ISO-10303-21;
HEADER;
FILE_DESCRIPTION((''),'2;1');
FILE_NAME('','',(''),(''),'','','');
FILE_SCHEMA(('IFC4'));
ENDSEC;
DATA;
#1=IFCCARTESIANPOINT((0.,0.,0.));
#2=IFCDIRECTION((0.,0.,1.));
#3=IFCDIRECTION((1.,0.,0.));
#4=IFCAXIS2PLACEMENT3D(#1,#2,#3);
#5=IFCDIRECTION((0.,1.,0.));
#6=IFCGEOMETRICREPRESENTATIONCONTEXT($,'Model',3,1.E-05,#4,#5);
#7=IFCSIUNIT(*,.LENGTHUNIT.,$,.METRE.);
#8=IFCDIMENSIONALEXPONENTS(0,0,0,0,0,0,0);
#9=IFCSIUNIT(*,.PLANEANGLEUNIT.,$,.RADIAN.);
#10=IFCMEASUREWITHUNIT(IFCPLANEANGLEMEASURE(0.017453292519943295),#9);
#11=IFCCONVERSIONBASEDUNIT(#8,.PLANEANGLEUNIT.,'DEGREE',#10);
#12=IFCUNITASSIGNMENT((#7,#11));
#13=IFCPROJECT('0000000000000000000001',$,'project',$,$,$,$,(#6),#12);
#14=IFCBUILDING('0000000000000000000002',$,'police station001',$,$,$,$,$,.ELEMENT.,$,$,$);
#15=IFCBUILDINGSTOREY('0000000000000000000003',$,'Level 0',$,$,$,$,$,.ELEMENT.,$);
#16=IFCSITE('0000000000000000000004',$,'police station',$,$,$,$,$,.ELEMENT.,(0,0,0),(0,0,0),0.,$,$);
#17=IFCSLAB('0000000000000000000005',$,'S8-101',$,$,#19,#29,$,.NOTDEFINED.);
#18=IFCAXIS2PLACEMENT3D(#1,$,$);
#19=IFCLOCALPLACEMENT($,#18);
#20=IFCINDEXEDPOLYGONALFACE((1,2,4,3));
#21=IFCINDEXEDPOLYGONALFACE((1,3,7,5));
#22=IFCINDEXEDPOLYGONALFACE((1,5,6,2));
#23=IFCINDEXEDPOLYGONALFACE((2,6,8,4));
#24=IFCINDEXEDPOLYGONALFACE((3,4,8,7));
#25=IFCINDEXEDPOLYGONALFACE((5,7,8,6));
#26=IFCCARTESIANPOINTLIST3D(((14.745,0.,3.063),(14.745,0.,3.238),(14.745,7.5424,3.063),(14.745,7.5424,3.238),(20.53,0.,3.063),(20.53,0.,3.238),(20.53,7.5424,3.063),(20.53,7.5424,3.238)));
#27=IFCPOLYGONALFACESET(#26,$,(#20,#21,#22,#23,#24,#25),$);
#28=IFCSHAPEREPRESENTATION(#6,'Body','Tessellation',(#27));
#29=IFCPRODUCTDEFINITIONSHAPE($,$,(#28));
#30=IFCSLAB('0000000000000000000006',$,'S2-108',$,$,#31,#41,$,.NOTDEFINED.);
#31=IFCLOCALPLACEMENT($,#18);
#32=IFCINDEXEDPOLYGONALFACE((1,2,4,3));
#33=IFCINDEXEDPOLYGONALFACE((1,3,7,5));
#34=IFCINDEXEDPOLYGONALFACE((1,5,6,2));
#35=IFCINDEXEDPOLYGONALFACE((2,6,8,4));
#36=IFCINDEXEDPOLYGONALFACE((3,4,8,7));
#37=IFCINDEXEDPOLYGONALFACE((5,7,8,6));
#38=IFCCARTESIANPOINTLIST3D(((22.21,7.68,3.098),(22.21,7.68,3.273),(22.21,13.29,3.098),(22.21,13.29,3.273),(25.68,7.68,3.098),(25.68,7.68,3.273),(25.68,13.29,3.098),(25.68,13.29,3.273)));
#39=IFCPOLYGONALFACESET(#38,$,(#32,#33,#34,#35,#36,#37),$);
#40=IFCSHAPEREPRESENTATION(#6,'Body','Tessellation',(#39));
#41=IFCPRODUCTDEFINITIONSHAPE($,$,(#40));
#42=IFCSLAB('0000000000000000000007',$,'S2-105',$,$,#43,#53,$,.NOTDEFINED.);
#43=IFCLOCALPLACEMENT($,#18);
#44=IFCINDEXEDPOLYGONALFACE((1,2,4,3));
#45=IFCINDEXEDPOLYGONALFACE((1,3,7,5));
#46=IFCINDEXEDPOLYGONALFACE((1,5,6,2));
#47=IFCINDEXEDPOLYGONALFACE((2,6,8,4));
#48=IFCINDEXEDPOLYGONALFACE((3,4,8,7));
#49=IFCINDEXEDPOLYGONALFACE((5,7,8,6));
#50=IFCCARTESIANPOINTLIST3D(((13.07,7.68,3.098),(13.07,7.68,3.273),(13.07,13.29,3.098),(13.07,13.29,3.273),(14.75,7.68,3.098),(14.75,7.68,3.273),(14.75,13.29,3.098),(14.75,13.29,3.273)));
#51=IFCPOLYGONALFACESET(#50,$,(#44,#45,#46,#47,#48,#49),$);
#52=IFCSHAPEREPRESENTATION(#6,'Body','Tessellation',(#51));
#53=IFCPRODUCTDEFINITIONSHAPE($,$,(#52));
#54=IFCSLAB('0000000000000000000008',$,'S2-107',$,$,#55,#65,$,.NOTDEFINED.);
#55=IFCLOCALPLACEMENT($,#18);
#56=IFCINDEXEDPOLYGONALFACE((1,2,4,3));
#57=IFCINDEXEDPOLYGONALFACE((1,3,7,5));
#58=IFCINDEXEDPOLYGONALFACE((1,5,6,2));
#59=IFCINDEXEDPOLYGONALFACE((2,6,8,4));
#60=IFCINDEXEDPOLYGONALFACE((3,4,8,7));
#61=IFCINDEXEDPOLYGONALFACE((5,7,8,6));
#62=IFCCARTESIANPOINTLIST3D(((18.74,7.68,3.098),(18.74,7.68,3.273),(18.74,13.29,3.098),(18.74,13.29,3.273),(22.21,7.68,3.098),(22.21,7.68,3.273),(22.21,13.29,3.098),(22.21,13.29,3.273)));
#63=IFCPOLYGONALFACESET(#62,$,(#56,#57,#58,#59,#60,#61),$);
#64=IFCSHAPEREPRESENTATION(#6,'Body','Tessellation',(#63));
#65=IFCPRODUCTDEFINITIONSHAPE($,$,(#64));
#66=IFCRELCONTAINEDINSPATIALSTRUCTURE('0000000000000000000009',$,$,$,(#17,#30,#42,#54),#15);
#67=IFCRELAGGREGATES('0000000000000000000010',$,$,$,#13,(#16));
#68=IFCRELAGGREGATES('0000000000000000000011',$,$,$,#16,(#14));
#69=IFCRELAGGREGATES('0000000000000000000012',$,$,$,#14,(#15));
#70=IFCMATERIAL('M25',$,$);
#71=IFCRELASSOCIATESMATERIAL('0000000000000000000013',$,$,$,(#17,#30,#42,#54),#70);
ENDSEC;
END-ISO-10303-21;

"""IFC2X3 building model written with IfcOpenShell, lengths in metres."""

from ifc_helpers import new_model, entity, si_unit, converted_unit, direction, frame, frame_2d, origin_with_axes, place, context, project, spatial, rectangle, extrude, material, element, save


model = new_model("IFC2X3")

# Units and contexts
model_context = context("Model", 3, precision=1e-05, world=origin_with_axes(), true_north=direction((0.0, 1.0, 0.0)))
ifc_project = project(units=[si_unit("LENGTHUNIT", "METRE"), converted_unit("PLANEANGLEUNIT", "DEGREE", entity("IfcPlaneAngleMeasure", 0.017453292519943295), si_unit("PLANEANGLEUNIT", "RADIAN"), dimensions=[0, 0, 0, 0, 0, 0, 0])], contexts=[model_context])

# Site, building, storey
site = spatial("IfcSite", under=ifc_project, Name="police station", CompositionType="ELEMENT", RefLatitude=(0, 0, 0), RefLongitude=(0, 0, 0), RefElevation=0.0)
building = spatial("IfcBuilding", under=site, Name="police station001", CompositionType="ELEMENT")
storey = spatial("IfcBuildingStorey", under=building, Name="Level 0", CompositionType="ELEMENT")

# Shared definitions
ifc_material = material(Name="M25")
placement = place(None, origin_with_axes())

# Slabs
element("IfcSlab", 1, at=placement, inside=storey, material=ifc_material, Name="S8-101", PredefinedType="NOTDEFINED", context=model_context, shape_type="SweptSolid", body=[
    extrude(rectangle(XDim=5.785, YDim=7.5424, at=frame_2d((0.0, 0.0), x_axis=(1.0, 0.0, 0.0))), frame((17.6375, 3.7712, 3.063), z_axis=(0.0, 0.0, 1.0), x_axis=(1.0, 0.0, 0.0)), (0.0, 0.0, 1.0), 0.175),
])
element("IfcSlab", 2, at=placement, inside=storey, material=ifc_material, Name="S2-108", PredefinedType="NOTDEFINED", context=model_context, shape_type="SweptSolid", body=[
    extrude(rectangle(XDim=3.47, YDim=5.61, at=frame_2d((0.0, 0.0), x_axis=(1.0, 0.0, 0.0))), frame((23.945, 10.485, 3.098), z_axis=(0.0, 0.0, 1.0), x_axis=(1.0, 0.0, 0.0)), (0.0, 0.0, 1.0), 0.175),
])
element("IfcSlab", 3, at=placement, inside=storey, material=ifc_material, Name="S2-105", PredefinedType="NOTDEFINED", context=model_context, shape_type="SweptSolid", body=[
    extrude(rectangle(XDim=1.68, YDim=5.61, at=frame_2d((0.0, 0.0), x_axis=(1.0, 0.0, 0.0))), frame((13.91, 10.485, 3.098), z_axis=(0.0, 0.0, 1.0), x_axis=(1.0, 0.0, 0.0)), (0.0, 0.0, 1.0), 0.175),
])
element("IfcSlab", 4, at=placement, inside=storey, material=ifc_material, Name="S2-107", PredefinedType="NOTDEFINED", context=model_context, shape_type="SweptSolid", body=[
    extrude(rectangle(XDim=3.47, YDim=5.61, at=frame_2d((0.0, 0.0), x_axis=(1.0, 0.0, 0.0))), frame((20.475, 10.485, 3.098), z_axis=(0.0, 0.0, 1.0), x_axis=(1.0, 0.0, 0.0)), (0.0, 0.0, 1.0), 0.175),
])

save(model, "model.ifc")
